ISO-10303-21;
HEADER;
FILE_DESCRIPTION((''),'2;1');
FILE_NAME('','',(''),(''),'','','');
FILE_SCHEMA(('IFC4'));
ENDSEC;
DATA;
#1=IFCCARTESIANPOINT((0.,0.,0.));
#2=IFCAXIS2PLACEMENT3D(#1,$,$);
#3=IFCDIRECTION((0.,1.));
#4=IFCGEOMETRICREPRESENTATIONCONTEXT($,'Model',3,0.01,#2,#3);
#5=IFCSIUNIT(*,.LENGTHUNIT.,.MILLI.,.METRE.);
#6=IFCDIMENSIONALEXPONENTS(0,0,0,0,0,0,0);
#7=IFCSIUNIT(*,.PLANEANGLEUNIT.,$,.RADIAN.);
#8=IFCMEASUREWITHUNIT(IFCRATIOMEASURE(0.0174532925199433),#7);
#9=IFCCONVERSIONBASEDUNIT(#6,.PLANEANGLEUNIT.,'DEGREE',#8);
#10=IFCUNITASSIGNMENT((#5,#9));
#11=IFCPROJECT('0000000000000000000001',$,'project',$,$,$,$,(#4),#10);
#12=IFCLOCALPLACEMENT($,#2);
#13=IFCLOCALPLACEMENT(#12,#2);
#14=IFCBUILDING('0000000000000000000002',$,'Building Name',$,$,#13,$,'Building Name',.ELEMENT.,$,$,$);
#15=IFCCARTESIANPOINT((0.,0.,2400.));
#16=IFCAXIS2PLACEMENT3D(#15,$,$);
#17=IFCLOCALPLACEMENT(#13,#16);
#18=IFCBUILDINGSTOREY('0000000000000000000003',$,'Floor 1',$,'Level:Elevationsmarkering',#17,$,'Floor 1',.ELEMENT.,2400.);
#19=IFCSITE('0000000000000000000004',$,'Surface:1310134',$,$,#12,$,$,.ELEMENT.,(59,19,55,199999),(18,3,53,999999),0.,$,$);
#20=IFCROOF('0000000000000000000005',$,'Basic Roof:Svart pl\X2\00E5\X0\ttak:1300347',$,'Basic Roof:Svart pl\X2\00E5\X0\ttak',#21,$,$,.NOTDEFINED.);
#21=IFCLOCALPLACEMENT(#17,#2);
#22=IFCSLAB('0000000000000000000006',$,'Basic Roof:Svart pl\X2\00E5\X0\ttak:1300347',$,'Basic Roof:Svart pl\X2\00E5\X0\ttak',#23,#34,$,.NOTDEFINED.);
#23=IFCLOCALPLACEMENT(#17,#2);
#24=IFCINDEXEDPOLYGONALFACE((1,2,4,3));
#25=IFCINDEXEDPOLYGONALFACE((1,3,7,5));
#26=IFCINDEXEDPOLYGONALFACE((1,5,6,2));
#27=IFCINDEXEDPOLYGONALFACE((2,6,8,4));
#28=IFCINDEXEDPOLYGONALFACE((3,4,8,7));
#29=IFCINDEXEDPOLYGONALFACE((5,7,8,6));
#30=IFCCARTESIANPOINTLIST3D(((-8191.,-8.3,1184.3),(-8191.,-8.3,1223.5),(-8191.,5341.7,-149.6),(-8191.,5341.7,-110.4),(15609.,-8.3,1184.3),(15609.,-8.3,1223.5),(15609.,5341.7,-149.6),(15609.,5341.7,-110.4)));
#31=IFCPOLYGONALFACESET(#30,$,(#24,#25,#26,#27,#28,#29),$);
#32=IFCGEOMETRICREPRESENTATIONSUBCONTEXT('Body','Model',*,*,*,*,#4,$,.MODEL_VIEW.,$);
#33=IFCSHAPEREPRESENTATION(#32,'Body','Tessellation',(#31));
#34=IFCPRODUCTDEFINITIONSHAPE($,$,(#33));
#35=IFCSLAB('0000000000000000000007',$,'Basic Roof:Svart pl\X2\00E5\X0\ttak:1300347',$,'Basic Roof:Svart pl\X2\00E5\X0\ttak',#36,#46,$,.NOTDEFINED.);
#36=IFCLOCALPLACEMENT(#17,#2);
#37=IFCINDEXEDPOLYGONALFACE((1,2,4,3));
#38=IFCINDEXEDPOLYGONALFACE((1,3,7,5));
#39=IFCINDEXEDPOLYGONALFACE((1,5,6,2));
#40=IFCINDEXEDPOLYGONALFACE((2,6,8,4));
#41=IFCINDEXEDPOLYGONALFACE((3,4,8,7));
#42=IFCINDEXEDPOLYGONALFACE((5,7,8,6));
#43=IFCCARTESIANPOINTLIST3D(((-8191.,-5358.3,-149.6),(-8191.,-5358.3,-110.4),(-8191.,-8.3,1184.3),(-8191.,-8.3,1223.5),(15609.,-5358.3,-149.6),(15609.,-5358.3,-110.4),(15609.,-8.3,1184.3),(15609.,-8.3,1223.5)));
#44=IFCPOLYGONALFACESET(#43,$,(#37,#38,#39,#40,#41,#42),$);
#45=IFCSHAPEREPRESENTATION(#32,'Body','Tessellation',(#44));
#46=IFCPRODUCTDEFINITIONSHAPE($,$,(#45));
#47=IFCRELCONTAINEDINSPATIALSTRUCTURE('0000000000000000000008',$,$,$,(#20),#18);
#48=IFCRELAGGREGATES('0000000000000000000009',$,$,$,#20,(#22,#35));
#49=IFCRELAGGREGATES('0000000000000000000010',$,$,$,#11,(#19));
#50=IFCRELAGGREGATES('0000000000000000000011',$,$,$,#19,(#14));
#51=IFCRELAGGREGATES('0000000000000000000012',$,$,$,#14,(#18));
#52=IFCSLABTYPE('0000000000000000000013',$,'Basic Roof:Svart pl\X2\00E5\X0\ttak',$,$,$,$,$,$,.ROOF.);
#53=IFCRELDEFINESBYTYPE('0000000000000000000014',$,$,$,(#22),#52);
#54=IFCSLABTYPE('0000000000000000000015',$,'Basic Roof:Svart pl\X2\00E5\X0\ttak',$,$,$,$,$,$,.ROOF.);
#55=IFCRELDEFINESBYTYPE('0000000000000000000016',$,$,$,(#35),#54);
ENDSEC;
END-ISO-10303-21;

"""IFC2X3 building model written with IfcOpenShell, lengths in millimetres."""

from ifc_helpers import new_model, entity, si_unit, converted_unit, direction, frame, frame_2d, origin, place, context, subcontext, project, spatial, rectangle, extrude, type_object, element, aggregate, save


model = new_model("IFC2X3")

# Units and contexts
model_context = context("Model", 3, precision=0.01, world=origin(), true_north=direction((0.0, 1.0)))
body_context = subcontext(model_context, "Body", "Model", "MODEL_VIEW")
ifc_project = project(units=[si_unit("LENGTHUNIT", "METRE", prefix="MILLI"), converted_unit("PLANEANGLEUNIT", "DEGREE", entity("IfcRatioMeasure", 0.0174532925199433), si_unit("PLANEANGLEUNIT", "RADIAN"), dimensions=[0, 0, 0, 0, 0, 0, 0])], contexts=[model_context])

# Site, building, storey
site_placement = place(None, origin())
site = spatial("IfcSite", under=ifc_project, at=site_placement, Name="Surface:1310134", CompositionType="ELEMENT", RefLatitude=(59, 19, 55, 199999), RefLongitude=(18, 3, 53, 999999), RefElevation=0.0)
building_placement = place(site_placement, origin())
building = spatial("IfcBuilding", under=site, at=building_placement, Name="Building Name", LongName="Building Name", CompositionType="ELEMENT")
storey_placement = place(building_placement, frame((0.0, 0.0, 2400.0)))
storey = spatial("IfcBuildingStorey", under=building, at=storey_placement, Name="Floor 1", ObjectType="Level:Elevationsmarkering", LongName="Floor 1", CompositionType="ELEMENT", Elevation=2400.0)

# Roof, slabs
roof_placement = place(storey_placement, frame((-8191.0, -5358.3, -149.6)))
roof = element("IfcRoof", 1, at=roof_placement, inside=storey, Name="Basic Roof:Svart plåttak:1300347", ObjectType="Basic Roof:Svart plåttak", ShapeType="NOTDEFINED")
slab_type_1 = type_object("IfcSlabType", Name="Basic Roof:Svart plåttak", PredefinedType="ROOF")
slab_1_placement = place(roof_placement, origin())
slab_1 = element("IfcSlab", 2, at=slab_1_placement, type_object=slab_type_1, Name="Basic Roof:Svart plåttak:1300347", ObjectType="Basic Roof:Svart plåttak", PredefinedType="NOTDEFINED", context=body_context, shape_type="SweptSolid", body=[
    extrude(rectangle(XDim=23800.0, YDim=5513.8, at=frame_2d((0.0, 0.0), x_axis=(1.0, 0.0))), frame((11900.0, 8025.0, 667.0), z_axis=(0.0, 0.241922, 0.970296), x_axis=(1.0, 0.0, 0.0)), (0.0, -0.241922, 0.970296), 39.2),
])
slab_type_2 = type_object("IfcSlabType", Name="Basic Roof:Svart plåttak", PredefinedType="ROOF")
slab_2_placement = place(roof_placement, origin())
slab_2 = element("IfcSlab", 3, at=slab_2_placement, type_object=slab_type_2, Name="Basic Roof:Svart plåttak:1300347", ObjectType="Basic Roof:Svart plåttak", PredefinedType="NOTDEFINED", context=body_context, shape_type="SweptSolid", body=[
    extrude(rectangle(XDim=5513.8, YDim=23800.0, at=frame_2d((0.0, 0.0), x_axis=(0.0, 1.0))), frame((11900.0, 2675.0, 667.0), z_axis=(0.0, -0.241922, 0.970296), x_axis=(1.0, 0.0, 0.0)), (0.0, 0.241922, 0.970296), 39.2),
])
aggregate(roof, [slab_1, slab_2])

save(model, "model.ifc")
